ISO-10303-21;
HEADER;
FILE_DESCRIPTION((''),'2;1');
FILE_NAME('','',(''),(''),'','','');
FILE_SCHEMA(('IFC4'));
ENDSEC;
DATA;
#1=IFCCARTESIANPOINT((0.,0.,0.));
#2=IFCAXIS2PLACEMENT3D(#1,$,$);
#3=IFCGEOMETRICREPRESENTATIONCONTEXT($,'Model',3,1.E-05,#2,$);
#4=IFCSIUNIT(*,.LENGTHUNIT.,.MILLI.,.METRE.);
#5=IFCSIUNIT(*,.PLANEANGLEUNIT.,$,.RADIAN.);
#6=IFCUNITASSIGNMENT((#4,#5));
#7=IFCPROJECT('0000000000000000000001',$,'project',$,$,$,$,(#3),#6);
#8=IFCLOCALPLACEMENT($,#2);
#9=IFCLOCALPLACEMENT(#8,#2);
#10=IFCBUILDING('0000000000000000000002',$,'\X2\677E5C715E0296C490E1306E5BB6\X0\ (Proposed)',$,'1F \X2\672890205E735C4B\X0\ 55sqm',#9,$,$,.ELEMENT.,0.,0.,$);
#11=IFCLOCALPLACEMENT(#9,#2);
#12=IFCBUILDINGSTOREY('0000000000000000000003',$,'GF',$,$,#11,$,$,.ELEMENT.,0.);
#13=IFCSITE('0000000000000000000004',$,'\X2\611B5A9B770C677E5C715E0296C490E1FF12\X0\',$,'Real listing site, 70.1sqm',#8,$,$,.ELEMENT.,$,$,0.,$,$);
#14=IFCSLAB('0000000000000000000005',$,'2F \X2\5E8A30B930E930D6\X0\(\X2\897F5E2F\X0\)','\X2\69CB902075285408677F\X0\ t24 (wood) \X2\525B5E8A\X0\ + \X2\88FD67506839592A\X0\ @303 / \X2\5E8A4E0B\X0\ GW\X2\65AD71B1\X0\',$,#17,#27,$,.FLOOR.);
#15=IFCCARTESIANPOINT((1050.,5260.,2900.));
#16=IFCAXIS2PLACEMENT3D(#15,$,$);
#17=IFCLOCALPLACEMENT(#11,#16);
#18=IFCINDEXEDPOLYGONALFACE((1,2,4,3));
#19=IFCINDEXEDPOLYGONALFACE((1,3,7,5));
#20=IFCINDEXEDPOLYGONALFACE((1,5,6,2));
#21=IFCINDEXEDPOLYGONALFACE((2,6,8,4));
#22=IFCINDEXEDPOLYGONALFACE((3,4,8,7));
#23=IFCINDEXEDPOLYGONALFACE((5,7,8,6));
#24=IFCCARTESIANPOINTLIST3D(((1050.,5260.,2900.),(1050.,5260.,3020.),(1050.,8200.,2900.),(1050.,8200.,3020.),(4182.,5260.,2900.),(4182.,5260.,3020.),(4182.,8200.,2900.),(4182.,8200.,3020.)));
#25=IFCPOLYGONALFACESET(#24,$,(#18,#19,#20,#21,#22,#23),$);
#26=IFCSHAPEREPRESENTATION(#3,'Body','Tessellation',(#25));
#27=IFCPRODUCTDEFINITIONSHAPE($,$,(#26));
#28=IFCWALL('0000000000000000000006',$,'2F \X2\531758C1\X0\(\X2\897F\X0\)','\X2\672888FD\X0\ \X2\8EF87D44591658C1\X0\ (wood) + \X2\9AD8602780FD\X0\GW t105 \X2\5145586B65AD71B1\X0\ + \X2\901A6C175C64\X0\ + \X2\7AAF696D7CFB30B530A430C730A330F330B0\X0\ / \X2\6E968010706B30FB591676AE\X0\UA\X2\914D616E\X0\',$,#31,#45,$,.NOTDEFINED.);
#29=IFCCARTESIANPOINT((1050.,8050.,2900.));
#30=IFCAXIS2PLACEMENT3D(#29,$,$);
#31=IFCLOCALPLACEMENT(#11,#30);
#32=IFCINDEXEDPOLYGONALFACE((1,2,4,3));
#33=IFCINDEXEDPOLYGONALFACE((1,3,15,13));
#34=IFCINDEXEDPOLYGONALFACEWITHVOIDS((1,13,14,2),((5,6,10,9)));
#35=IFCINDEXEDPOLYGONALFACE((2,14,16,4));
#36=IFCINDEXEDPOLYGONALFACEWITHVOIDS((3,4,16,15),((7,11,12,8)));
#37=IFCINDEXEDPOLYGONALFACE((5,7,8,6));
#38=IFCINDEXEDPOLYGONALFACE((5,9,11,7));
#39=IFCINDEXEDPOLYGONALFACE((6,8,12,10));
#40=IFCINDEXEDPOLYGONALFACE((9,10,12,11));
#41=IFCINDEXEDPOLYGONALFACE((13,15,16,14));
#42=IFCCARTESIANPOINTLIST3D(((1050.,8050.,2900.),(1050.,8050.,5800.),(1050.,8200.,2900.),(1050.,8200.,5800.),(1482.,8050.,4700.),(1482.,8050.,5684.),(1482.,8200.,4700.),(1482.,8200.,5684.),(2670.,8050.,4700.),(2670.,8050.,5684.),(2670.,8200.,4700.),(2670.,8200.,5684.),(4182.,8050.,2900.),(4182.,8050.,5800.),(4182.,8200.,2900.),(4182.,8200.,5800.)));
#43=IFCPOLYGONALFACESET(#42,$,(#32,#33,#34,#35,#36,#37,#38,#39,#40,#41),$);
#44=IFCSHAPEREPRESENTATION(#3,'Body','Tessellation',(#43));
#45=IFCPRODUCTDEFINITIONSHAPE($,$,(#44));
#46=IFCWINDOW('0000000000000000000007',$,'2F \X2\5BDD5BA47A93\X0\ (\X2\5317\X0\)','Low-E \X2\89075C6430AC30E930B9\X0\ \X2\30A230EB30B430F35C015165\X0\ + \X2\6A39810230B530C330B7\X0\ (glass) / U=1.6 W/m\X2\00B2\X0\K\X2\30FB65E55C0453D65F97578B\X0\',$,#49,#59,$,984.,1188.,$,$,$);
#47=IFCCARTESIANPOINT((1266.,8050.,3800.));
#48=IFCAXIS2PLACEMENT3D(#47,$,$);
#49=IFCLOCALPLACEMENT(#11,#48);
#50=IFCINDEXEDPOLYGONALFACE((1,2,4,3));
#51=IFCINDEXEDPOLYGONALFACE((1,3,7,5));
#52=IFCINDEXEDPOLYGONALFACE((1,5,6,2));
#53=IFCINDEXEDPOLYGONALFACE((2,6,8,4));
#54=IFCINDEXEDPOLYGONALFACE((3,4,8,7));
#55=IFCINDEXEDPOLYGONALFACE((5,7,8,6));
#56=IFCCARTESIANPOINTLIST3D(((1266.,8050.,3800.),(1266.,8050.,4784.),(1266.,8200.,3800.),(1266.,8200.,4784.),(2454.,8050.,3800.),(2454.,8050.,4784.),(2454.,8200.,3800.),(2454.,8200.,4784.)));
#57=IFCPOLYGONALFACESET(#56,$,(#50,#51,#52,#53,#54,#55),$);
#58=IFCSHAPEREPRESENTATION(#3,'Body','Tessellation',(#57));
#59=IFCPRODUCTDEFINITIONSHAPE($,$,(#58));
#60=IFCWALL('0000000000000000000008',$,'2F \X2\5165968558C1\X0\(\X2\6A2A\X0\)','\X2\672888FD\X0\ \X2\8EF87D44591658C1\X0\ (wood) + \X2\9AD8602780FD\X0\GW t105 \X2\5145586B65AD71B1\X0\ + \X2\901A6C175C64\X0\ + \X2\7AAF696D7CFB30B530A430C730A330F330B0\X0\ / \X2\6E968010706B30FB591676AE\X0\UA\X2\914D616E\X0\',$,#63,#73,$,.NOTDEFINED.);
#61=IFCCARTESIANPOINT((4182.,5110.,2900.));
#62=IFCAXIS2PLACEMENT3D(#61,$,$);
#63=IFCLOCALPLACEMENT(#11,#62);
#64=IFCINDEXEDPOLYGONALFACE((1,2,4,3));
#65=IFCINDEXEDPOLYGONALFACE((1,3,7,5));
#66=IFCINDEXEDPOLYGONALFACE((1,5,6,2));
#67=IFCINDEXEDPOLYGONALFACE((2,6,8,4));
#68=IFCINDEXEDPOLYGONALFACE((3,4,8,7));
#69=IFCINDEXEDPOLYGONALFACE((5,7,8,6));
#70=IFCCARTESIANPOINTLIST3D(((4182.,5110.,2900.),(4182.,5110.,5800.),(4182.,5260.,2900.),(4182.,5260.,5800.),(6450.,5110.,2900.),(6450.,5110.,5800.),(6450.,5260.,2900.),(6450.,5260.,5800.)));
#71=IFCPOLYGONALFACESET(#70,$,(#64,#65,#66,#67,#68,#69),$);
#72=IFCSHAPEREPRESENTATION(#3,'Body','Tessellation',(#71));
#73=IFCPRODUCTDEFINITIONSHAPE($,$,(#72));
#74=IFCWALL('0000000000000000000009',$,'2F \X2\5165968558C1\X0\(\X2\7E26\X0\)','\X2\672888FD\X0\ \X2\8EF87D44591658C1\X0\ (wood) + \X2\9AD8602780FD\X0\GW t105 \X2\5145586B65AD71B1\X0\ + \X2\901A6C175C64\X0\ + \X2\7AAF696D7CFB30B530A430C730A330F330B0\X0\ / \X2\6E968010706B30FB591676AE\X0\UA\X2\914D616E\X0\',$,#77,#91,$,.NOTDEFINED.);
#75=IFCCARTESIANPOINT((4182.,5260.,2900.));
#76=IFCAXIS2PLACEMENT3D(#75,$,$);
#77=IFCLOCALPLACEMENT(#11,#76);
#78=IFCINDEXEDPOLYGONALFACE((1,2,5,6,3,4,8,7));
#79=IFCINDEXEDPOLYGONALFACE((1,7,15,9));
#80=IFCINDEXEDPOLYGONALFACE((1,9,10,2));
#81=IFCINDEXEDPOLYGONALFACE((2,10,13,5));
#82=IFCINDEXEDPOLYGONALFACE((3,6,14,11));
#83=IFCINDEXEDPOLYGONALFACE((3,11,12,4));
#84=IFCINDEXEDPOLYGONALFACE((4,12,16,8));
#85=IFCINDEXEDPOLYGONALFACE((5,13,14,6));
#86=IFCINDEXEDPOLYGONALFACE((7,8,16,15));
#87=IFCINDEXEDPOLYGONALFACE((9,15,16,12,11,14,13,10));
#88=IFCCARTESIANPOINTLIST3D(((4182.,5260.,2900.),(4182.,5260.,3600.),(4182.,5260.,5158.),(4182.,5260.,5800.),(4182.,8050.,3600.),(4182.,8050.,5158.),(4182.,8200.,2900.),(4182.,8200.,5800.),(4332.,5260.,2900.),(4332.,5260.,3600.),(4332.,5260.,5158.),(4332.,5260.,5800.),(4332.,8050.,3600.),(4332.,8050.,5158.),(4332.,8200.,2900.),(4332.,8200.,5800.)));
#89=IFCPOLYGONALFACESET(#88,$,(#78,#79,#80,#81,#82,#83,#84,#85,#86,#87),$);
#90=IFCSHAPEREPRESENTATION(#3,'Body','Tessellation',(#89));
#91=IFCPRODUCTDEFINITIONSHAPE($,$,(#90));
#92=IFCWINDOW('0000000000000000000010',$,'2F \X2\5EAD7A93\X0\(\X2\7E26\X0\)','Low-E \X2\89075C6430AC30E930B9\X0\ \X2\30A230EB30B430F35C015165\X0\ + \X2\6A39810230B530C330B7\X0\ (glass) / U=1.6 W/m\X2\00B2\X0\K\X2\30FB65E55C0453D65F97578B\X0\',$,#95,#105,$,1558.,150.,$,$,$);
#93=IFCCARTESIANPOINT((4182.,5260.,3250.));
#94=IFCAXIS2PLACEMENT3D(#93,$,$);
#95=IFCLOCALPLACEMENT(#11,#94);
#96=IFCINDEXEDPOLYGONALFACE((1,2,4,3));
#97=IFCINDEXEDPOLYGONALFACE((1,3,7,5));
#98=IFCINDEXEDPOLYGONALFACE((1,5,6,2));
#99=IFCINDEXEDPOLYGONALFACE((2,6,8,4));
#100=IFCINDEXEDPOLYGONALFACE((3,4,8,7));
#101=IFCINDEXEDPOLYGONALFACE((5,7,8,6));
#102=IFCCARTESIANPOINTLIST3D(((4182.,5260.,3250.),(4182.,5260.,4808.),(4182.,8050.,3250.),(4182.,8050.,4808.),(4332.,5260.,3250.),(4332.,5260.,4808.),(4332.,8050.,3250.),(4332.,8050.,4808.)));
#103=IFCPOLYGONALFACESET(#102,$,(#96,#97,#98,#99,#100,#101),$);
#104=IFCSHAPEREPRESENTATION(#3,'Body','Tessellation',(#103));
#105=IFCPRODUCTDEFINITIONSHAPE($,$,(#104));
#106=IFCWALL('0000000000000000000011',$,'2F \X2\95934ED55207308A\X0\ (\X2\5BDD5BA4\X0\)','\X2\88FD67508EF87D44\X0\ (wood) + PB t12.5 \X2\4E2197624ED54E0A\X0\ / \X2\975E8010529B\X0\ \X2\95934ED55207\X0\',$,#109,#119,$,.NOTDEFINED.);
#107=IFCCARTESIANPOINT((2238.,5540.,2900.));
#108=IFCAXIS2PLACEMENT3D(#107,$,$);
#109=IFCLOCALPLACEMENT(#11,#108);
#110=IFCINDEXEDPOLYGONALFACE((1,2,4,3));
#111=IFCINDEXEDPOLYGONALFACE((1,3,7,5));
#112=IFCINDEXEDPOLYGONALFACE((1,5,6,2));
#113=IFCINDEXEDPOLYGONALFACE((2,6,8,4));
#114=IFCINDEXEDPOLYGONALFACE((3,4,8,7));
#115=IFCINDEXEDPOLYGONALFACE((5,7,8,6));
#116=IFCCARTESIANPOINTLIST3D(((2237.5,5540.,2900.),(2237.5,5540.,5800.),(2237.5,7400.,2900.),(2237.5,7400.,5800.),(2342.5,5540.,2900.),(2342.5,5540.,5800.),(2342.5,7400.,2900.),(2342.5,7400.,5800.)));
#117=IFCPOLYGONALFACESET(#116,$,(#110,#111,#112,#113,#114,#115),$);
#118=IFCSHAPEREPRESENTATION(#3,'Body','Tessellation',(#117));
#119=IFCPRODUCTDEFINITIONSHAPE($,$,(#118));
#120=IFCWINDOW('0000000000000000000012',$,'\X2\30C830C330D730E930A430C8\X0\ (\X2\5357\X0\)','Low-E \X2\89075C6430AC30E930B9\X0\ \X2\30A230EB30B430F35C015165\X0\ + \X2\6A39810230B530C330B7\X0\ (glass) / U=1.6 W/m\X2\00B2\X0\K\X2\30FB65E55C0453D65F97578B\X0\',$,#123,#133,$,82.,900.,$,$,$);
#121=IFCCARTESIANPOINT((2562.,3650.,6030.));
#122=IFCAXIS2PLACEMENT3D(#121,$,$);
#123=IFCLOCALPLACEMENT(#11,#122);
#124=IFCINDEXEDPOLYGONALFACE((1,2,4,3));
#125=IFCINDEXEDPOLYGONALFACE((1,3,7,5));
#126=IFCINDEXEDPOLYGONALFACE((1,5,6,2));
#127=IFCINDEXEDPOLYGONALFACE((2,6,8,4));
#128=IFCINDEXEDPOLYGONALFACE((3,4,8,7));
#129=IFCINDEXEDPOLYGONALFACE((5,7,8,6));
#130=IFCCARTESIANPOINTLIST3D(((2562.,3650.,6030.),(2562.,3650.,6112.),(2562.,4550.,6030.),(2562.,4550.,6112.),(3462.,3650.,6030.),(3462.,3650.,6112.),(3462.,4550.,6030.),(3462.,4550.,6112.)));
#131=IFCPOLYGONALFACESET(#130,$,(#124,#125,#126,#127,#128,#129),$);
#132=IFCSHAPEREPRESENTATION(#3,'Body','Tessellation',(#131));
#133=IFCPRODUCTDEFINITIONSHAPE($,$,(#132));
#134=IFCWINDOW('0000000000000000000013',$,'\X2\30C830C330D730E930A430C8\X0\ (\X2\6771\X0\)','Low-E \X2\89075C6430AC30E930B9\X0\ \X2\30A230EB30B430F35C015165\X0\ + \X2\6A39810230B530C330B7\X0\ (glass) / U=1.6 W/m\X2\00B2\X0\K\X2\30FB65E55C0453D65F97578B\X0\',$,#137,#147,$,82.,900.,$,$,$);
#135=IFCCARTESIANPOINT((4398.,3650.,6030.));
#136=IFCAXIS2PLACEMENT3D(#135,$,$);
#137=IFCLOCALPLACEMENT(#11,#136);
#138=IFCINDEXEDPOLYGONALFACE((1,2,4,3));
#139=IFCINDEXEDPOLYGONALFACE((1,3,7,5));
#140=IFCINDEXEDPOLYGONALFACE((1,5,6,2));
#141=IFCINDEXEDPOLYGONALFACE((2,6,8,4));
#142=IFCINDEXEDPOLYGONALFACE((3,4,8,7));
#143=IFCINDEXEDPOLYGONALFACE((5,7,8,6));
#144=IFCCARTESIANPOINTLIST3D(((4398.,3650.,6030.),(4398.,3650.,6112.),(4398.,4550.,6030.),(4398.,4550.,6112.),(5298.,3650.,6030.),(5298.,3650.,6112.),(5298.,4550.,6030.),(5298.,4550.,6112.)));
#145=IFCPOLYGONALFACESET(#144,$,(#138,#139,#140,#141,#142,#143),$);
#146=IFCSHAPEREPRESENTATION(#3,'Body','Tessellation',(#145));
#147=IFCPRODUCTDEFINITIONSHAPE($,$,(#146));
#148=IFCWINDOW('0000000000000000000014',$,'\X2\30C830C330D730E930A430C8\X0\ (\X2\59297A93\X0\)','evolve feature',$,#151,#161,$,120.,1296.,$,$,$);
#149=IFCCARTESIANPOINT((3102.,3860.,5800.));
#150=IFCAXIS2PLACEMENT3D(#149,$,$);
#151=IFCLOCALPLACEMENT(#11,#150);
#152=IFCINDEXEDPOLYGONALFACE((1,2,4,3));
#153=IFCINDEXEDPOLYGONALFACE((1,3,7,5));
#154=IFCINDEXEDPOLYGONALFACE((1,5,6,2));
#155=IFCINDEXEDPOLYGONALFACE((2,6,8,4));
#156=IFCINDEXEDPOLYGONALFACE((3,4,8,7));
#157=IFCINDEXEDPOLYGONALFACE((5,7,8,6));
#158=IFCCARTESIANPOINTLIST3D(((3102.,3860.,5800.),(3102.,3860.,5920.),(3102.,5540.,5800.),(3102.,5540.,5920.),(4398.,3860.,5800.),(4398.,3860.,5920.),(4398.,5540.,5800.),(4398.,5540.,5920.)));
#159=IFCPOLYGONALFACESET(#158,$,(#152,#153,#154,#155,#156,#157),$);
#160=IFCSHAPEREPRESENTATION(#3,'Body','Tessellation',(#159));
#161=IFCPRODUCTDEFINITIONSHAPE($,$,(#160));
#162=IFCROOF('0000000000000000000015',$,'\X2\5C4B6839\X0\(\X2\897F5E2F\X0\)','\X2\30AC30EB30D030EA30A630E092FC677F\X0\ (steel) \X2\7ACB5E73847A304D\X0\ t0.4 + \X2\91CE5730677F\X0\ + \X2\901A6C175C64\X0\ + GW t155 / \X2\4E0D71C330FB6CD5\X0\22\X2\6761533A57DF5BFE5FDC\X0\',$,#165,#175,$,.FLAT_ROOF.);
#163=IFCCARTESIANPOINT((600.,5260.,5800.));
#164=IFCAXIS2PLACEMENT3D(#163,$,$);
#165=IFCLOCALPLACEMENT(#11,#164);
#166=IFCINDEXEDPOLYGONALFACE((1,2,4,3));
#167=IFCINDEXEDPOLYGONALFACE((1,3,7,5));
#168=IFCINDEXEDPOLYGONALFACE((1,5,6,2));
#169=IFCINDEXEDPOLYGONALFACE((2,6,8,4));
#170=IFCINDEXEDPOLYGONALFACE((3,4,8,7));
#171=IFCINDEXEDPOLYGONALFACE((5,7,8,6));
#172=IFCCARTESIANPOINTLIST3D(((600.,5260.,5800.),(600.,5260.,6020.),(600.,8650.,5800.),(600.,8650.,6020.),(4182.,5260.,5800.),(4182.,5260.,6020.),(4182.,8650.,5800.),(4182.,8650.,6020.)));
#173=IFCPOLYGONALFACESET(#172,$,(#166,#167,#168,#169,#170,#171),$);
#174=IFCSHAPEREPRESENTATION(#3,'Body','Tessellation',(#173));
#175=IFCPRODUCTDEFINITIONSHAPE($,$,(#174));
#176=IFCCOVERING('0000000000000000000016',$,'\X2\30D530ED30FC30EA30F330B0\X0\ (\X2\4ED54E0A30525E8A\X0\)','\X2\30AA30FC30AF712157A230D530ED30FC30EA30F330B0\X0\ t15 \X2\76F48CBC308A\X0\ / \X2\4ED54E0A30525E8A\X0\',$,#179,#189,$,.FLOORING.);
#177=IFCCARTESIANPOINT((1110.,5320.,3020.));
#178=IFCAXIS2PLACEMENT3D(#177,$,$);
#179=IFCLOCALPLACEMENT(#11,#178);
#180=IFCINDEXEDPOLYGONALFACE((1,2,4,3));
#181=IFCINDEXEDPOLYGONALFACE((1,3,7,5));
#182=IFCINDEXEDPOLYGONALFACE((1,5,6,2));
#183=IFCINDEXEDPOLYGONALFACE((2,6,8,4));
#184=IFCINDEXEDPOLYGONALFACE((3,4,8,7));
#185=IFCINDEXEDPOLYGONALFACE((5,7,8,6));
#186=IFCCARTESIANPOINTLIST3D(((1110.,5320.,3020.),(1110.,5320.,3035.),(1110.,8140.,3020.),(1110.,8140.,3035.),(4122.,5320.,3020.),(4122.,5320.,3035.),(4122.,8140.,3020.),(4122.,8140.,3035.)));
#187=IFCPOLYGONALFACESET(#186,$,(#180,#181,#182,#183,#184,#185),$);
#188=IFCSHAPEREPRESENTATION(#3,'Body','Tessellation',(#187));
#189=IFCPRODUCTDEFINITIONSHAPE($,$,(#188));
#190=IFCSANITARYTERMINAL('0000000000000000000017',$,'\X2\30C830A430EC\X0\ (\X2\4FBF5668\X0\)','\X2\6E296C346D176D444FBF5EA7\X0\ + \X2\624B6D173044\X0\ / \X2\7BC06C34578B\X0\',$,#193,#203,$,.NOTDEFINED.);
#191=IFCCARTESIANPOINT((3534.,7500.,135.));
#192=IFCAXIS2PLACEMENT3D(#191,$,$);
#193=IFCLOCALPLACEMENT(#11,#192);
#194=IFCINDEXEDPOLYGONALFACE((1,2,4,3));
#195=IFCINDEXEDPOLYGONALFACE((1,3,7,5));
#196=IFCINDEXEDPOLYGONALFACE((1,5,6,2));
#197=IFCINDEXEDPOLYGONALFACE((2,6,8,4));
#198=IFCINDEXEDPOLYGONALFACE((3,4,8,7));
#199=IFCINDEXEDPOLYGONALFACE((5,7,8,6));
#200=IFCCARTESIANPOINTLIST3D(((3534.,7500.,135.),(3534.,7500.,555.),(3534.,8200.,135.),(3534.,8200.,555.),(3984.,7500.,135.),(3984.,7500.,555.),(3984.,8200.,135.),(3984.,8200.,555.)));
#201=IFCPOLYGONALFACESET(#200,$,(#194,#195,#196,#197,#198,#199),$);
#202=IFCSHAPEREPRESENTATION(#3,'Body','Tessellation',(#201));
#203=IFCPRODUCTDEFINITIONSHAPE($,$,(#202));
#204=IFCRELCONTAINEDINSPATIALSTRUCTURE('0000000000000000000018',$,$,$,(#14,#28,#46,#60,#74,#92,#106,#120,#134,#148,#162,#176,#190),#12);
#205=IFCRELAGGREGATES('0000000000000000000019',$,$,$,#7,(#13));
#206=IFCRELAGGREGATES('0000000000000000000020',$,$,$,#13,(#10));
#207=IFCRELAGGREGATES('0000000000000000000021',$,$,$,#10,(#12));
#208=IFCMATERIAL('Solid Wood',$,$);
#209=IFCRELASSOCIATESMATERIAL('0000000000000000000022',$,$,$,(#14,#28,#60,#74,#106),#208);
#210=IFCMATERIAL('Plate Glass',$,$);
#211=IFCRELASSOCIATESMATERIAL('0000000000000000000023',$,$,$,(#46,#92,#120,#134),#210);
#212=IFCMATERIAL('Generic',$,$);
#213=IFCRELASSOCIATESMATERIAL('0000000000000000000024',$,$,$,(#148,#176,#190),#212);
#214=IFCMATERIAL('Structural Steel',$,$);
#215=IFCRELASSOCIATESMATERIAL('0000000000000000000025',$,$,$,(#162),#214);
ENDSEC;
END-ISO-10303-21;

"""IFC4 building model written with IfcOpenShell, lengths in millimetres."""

from ifc_helpers import new_model, si_unit, frame, frame_2d, origin, place, context, project, spatial, rectangle, extrude, material, element, fill, save


model = new_model("IFC4")

# Units and contexts
model_context = context("Model", 3, precision=1e-05, world=origin())
ifc_project = project(units=[si_unit("LENGTHUNIT", "METRE", prefix="MILLI"), si_unit("PLANEANGLEUNIT", "RADIAN")], contexts=[model_context])

# Site, building, storey
site_placement = place(None, origin())
site = spatial("IfcSite", under=ifc_project, at=site_placement, Name="愛媛県松山市雄郡２", ObjectType="Real listing site, 70.1sqm", CompositionType="ELEMENT", RefElevation=0.0)
building_placement = place(site_placement, origin())
building = spatial("IfcBuilding", under=site, at=building_placement, Name="松山市雄郡の家 (Proposed)", ObjectType="1F 木造平屋 55sqm", CompositionType="ELEMENT", ElevationOfRefHeight=0.0, ElevationOfTerrain=0.0)
storey_placement = place(building_placement, origin())
storey = spatial("IfcBuildingStorey", under=building, at=storey_placement, Name="GF", CompositionType="ELEMENT", Elevation=0.0)

# Slab
ifc_material_1 = material(Name="Solid Wood")
slab_placement = place(storey_placement, frame((1050.0, 5260.0, 2900.0)))
element("IfcSlab", 1, at=slab_placement, inside=storey, material=ifc_material_1, Name="2F 床スラブ(西帯)", Description="構造用合板 t24 (wood) 剛床 + 製材根太 @303 / 床下 GW断熱", PredefinedType="FLOOR", context=model_context, shape_type="SweptSolid", body=[
    extrude(rectangle(XDim=3132.0, YDim=2940.0, at=frame_2d((1566.0, 1470.0))), frame((1050.0, 5260.0, 2900.0)), (0.0, 0.0, 1.0), 120.0),
])

# Wall, opening, window
wall_1_placement = place(storey_placement, frame((1050.0, 8050.0, 2900.0)))
wall_1 = element("IfcWall", 2, at=wall_1_placement, inside=storey, material=ifc_material_1, Name="2F 北壁(西)", Description="木製 軸組外壁 (wood) + 高性能GW t105 充填断熱 + 通気層 + 窯業系サイディング / 準耐火・外皮UA配慮", PredefinedType="NOTDEFINED", context=model_context, shape_type="SweptSolid", body=[
    extrude(rectangle(XDim=3132.0, YDim=150.0, at=frame_2d((1566.0, 75.0))), frame((1050.0, 8050.0, 2900.0)), (0.0, 0.0, 1.0), 2900.0),
])
opening_1_placement = place(storey_placement, frame((1266.0, 8050.0, 3800.0)))
opening_1 = element("IfcOpeningElement", 3, at=opening_1_placement, cuts=wall_1, PredefinedType="NOTDEFINED", context=model_context, shape_type="SweptSolid", body=[
    extrude(rectangle(XDim=1188.0, YDim=150.0, at=frame_2d((594.0, 75.0))), frame((1266.0, 8050.0, 3800.0)), (0.0, 0.0, 1.0), 984.0),
])
ifc_material_2 = material(Name="Plate Glass")
window_1_placement = place(storey_placement, frame((1266.0, 8050.0, 3800.0)))
window_1 = element("IfcWindow", 4, at=window_1_placement, inside=storey, material=ifc_material_2, Name="2F 寝室窓 (北)", Description="Low-E 複層ガラス アルゴン封入 + 樹脂サッシ (glass) / U=1.6 W/m²K・日射取得型", OverallHeight=984.0, OverallWidth=1188.0, context=model_context, shape_type="SweptSolid", body=[
    extrude(rectangle(XDim=1188.0, YDim=150.0, at=frame_2d((594.0, 75.0))), frame((1266.0, 8050.0, 3800.0)), (0.0, 0.0, 1.0), 984.0),
])
fill(opening_1, window_1)

# Wall
wall_2_placement = place(storey_placement, frame((4182.0, 5110.0, 2900.0)))
element("IfcWall", 5, at=wall_2_placement, inside=storey, material=ifc_material_1, Name="2F 入隅壁(横)", Description="木製 軸組外壁 (wood) + 高性能GW t105 充填断熱 + 通気層 + 窯業系サイディング / 準耐火・外皮UA配慮", PredefinedType="NOTDEFINED", context=model_context, shape_type="SweptSolid", body=[
    extrude(rectangle(XDim=2268.0, YDim=150.0, at=frame_2d((1134.0, 75.0))), frame((4182.0, 5110.0, 2900.0)), (0.0, 0.0, 1.0), 2900.0),
])

# Wall, opening, window
wall_3_placement = place(storey_placement, frame((4182.0, 5260.0, 2900.0)))
wall_3 = element("IfcWall", 6, at=wall_3_placement, inside=storey, material=ifc_material_1, Name="2F 入隅壁(縦)", Description="木製 軸組外壁 (wood) + 高性能GW t105 充填断熱 + 通気層 + 窯業系サイディング / 準耐火・外皮UA配慮", PredefinedType="NOTDEFINED", context=model_context, shape_type="SweptSolid", body=[
    extrude(rectangle(XDim=150.0, YDim=2940.0, at=frame_2d((75.0, 1470.0))), frame((4182.0, 5260.0, 2900.0)), (0.0, 0.0, 1.0), 2900.0),
])
opening_2_placement = place(storey_placement, frame((4182.0, 5260.0, 3250.0)))
opening_2 = element("IfcOpeningElement", 7, at=opening_2_placement, cuts=wall_3, PredefinedType="NOTDEFINED", context=model_context, shape_type="SweptSolid", body=[
    extrude(rectangle(XDim=150.0, YDim=2790.0, at=frame_2d((75.0, 1395.0))), frame((4182.0, 5260.0, 3250.0)), (0.0, 0.0, 1.0), 1558.0),
])
window_2_placement = place(storey_placement, frame((4182.0, 5260.0, 3250.0)))
window_2 = element("IfcWindow", 8, at=window_2_placement, inside=storey, material=ifc_material_2, Name="2F 庭窓(縦)", Description="Low-E 複層ガラス アルゴン封入 + 樹脂サッシ (glass) / U=1.6 W/m²K・日射取得型", OverallHeight=1558.0, OverallWidth=150.0, context=model_context, shape_type="SweptSolid", body=[
    extrude(rectangle(XDim=150.0, YDim=2790.0, at=frame_2d((75.0, 1395.0))), frame((4182.0, 5260.0, 3250.0)), (0.0, 0.0, 1.0), 1558.0),
])
fill(opening_2, window_2)

# Wall
wall_4_placement = place(storey_placement, frame((2238.0, 5540.0, 2900.0)))
element("IfcWall", 9, at=wall_4_placement, inside=storey, material=ifc_material_1, Name="2F 間仕切り (寝室)", Description="製材軸組 (wood) + PB t12.5 両面仕上 / 非耐力 間仕切", PredefinedType="NOTDEFINED", context=model_context, shape_type="SweptSolid", body=[
    extrude(rectangle(XDim=105.0, YDim=1860.0, at=frame_2d((52.0, 930.0))), frame((2238.0, 5540.0, 2900.0)), (0.0, 0.0, 1.0), 2900.0),
])

# Windows
window_3_placement = place(storey_placement, frame((2562.0, 3650.0, 6030.0)))
element("IfcWindow", 10, at=window_3_placement, inside=storey, material=ifc_material_2, Name="トップライト (南)", Description="Low-E 複層ガラス アルゴン封入 + 樹脂サッシ (glass) / U=1.6 W/m²K・日射取得型", OverallHeight=82.0, OverallWidth=900.0, context=model_context, shape_type="SweptSolid", body=[
    extrude(rectangle(XDim=900.0, YDim=900.0, at=frame_2d((450.0, 450.0))), frame((2562.0, 3650.0, 6030.0)), (0.0, 0.0, 1.0), 82.0),
])
window_4_placement = place(storey_placement, frame((4398.0, 3650.0, 6030.0)))
element("IfcWindow", 11, at=window_4_placement, inside=storey, material=ifc_material_2, Name="トップライト (東)", Description="Low-E 複層ガラス アルゴン封入 + 樹脂サッシ (glass) / U=1.6 W/m²K・日射取得型", OverallHeight=82.0, OverallWidth=900.0, context=model_context, shape_type="SweptSolid", body=[
    extrude(rectangle(XDim=900.0, YDim=900.0, at=frame_2d((450.0, 450.0))), frame((4398.0, 3650.0, 6030.0)), (0.0, 0.0, 1.0), 82.0),
])
ifc_material_3 = material(Name="Generic")
window_5_placement = place(storey_placement, frame((3102.0, 3860.0, 5800.0)))
element("IfcWindow", 12, at=window_5_placement, inside=storey, material=ifc_material_3, Name="トップライト (天窓)", Description="evolve feature", OverallHeight=120.0, OverallWidth=1296.0, context=model_context, shape_type="SweptSolid", body=[
    extrude(rectangle(XDim=1296.0, YDim=1680.0, at=frame_2d((648.0, 840.0))), frame((3102.0, 3860.0, 5800.0)), (0.0, 0.0, 1.0), 120.0),
])

# Roof
ifc_material_4 = material(Name="Structural Steel")
for number, where, name in (
    (13, (600.0, 5260.0, 5800.0), "屋根(西帯)"),
):
    element("IfcRoof", number, at=place(storey_placement, frame(where)), inside=storey, material=ifc_material_4, Name=name, Description="ガルバリウム鋼板 (steel) 立平葺き t0.4 + 野地板 + 通気層 + GW t155 / 不燃・法22条区域対応", PredefinedType="FLAT_ROOF", context=model_context, shape_type="SweptSolid", body=[
        extrude(rectangle(XDim=3582.0, YDim=3390.0, at=frame_2d((1791.0, 1695.0))), frame((600.0, 5260.0, 5800.0)), (0.0, 0.0, 1.0), 220.0),
    ])

# Covering
covering_placement = place(storey_placement, frame((1110.0, 5320.0, 3020.0)))
element("IfcCovering", 14, at=covering_placement, inside=storey, material=ifc_material_3, Name="フローリング (仕上げ床)", Description="オーク無垢フローリング t15 直貼り / 仕上げ床", PredefinedType="FLOORING", context=model_context, shape_type="SweptSolid", body=[
    extrude(rectangle(XDim=3012.0, YDim=2820.0, at=frame_2d((1506.0, 1410.0))), frame((1110.0, 5320.0, 3020.0)), (0.0, 0.0, 1.0), 15.0),
])

# Sanitary terminal
sanitary_terminal_placement = place(storey_placement, frame((3534.0, 7500.0, 135.0)))
element("IfcSanitaryTerminal", 15, at=sanitary_terminal_placement, inside=storey, material=ifc_material_3, Name="トイレ (便器)", Description="温水洗浄便座 + 手洗い / 節水型", PredefinedType="NOTDEFINED", context=model_context, shape_type="SweptSolid", body=[
    extrude(rectangle(XDim=450.0, YDim=700.0, at=frame_2d((225.0, 350.0))), frame((3534.0, 7500.0, 135.0)), (0.0, 0.0, 1.0), 420.0),
])

save(model, "model.ifc")
